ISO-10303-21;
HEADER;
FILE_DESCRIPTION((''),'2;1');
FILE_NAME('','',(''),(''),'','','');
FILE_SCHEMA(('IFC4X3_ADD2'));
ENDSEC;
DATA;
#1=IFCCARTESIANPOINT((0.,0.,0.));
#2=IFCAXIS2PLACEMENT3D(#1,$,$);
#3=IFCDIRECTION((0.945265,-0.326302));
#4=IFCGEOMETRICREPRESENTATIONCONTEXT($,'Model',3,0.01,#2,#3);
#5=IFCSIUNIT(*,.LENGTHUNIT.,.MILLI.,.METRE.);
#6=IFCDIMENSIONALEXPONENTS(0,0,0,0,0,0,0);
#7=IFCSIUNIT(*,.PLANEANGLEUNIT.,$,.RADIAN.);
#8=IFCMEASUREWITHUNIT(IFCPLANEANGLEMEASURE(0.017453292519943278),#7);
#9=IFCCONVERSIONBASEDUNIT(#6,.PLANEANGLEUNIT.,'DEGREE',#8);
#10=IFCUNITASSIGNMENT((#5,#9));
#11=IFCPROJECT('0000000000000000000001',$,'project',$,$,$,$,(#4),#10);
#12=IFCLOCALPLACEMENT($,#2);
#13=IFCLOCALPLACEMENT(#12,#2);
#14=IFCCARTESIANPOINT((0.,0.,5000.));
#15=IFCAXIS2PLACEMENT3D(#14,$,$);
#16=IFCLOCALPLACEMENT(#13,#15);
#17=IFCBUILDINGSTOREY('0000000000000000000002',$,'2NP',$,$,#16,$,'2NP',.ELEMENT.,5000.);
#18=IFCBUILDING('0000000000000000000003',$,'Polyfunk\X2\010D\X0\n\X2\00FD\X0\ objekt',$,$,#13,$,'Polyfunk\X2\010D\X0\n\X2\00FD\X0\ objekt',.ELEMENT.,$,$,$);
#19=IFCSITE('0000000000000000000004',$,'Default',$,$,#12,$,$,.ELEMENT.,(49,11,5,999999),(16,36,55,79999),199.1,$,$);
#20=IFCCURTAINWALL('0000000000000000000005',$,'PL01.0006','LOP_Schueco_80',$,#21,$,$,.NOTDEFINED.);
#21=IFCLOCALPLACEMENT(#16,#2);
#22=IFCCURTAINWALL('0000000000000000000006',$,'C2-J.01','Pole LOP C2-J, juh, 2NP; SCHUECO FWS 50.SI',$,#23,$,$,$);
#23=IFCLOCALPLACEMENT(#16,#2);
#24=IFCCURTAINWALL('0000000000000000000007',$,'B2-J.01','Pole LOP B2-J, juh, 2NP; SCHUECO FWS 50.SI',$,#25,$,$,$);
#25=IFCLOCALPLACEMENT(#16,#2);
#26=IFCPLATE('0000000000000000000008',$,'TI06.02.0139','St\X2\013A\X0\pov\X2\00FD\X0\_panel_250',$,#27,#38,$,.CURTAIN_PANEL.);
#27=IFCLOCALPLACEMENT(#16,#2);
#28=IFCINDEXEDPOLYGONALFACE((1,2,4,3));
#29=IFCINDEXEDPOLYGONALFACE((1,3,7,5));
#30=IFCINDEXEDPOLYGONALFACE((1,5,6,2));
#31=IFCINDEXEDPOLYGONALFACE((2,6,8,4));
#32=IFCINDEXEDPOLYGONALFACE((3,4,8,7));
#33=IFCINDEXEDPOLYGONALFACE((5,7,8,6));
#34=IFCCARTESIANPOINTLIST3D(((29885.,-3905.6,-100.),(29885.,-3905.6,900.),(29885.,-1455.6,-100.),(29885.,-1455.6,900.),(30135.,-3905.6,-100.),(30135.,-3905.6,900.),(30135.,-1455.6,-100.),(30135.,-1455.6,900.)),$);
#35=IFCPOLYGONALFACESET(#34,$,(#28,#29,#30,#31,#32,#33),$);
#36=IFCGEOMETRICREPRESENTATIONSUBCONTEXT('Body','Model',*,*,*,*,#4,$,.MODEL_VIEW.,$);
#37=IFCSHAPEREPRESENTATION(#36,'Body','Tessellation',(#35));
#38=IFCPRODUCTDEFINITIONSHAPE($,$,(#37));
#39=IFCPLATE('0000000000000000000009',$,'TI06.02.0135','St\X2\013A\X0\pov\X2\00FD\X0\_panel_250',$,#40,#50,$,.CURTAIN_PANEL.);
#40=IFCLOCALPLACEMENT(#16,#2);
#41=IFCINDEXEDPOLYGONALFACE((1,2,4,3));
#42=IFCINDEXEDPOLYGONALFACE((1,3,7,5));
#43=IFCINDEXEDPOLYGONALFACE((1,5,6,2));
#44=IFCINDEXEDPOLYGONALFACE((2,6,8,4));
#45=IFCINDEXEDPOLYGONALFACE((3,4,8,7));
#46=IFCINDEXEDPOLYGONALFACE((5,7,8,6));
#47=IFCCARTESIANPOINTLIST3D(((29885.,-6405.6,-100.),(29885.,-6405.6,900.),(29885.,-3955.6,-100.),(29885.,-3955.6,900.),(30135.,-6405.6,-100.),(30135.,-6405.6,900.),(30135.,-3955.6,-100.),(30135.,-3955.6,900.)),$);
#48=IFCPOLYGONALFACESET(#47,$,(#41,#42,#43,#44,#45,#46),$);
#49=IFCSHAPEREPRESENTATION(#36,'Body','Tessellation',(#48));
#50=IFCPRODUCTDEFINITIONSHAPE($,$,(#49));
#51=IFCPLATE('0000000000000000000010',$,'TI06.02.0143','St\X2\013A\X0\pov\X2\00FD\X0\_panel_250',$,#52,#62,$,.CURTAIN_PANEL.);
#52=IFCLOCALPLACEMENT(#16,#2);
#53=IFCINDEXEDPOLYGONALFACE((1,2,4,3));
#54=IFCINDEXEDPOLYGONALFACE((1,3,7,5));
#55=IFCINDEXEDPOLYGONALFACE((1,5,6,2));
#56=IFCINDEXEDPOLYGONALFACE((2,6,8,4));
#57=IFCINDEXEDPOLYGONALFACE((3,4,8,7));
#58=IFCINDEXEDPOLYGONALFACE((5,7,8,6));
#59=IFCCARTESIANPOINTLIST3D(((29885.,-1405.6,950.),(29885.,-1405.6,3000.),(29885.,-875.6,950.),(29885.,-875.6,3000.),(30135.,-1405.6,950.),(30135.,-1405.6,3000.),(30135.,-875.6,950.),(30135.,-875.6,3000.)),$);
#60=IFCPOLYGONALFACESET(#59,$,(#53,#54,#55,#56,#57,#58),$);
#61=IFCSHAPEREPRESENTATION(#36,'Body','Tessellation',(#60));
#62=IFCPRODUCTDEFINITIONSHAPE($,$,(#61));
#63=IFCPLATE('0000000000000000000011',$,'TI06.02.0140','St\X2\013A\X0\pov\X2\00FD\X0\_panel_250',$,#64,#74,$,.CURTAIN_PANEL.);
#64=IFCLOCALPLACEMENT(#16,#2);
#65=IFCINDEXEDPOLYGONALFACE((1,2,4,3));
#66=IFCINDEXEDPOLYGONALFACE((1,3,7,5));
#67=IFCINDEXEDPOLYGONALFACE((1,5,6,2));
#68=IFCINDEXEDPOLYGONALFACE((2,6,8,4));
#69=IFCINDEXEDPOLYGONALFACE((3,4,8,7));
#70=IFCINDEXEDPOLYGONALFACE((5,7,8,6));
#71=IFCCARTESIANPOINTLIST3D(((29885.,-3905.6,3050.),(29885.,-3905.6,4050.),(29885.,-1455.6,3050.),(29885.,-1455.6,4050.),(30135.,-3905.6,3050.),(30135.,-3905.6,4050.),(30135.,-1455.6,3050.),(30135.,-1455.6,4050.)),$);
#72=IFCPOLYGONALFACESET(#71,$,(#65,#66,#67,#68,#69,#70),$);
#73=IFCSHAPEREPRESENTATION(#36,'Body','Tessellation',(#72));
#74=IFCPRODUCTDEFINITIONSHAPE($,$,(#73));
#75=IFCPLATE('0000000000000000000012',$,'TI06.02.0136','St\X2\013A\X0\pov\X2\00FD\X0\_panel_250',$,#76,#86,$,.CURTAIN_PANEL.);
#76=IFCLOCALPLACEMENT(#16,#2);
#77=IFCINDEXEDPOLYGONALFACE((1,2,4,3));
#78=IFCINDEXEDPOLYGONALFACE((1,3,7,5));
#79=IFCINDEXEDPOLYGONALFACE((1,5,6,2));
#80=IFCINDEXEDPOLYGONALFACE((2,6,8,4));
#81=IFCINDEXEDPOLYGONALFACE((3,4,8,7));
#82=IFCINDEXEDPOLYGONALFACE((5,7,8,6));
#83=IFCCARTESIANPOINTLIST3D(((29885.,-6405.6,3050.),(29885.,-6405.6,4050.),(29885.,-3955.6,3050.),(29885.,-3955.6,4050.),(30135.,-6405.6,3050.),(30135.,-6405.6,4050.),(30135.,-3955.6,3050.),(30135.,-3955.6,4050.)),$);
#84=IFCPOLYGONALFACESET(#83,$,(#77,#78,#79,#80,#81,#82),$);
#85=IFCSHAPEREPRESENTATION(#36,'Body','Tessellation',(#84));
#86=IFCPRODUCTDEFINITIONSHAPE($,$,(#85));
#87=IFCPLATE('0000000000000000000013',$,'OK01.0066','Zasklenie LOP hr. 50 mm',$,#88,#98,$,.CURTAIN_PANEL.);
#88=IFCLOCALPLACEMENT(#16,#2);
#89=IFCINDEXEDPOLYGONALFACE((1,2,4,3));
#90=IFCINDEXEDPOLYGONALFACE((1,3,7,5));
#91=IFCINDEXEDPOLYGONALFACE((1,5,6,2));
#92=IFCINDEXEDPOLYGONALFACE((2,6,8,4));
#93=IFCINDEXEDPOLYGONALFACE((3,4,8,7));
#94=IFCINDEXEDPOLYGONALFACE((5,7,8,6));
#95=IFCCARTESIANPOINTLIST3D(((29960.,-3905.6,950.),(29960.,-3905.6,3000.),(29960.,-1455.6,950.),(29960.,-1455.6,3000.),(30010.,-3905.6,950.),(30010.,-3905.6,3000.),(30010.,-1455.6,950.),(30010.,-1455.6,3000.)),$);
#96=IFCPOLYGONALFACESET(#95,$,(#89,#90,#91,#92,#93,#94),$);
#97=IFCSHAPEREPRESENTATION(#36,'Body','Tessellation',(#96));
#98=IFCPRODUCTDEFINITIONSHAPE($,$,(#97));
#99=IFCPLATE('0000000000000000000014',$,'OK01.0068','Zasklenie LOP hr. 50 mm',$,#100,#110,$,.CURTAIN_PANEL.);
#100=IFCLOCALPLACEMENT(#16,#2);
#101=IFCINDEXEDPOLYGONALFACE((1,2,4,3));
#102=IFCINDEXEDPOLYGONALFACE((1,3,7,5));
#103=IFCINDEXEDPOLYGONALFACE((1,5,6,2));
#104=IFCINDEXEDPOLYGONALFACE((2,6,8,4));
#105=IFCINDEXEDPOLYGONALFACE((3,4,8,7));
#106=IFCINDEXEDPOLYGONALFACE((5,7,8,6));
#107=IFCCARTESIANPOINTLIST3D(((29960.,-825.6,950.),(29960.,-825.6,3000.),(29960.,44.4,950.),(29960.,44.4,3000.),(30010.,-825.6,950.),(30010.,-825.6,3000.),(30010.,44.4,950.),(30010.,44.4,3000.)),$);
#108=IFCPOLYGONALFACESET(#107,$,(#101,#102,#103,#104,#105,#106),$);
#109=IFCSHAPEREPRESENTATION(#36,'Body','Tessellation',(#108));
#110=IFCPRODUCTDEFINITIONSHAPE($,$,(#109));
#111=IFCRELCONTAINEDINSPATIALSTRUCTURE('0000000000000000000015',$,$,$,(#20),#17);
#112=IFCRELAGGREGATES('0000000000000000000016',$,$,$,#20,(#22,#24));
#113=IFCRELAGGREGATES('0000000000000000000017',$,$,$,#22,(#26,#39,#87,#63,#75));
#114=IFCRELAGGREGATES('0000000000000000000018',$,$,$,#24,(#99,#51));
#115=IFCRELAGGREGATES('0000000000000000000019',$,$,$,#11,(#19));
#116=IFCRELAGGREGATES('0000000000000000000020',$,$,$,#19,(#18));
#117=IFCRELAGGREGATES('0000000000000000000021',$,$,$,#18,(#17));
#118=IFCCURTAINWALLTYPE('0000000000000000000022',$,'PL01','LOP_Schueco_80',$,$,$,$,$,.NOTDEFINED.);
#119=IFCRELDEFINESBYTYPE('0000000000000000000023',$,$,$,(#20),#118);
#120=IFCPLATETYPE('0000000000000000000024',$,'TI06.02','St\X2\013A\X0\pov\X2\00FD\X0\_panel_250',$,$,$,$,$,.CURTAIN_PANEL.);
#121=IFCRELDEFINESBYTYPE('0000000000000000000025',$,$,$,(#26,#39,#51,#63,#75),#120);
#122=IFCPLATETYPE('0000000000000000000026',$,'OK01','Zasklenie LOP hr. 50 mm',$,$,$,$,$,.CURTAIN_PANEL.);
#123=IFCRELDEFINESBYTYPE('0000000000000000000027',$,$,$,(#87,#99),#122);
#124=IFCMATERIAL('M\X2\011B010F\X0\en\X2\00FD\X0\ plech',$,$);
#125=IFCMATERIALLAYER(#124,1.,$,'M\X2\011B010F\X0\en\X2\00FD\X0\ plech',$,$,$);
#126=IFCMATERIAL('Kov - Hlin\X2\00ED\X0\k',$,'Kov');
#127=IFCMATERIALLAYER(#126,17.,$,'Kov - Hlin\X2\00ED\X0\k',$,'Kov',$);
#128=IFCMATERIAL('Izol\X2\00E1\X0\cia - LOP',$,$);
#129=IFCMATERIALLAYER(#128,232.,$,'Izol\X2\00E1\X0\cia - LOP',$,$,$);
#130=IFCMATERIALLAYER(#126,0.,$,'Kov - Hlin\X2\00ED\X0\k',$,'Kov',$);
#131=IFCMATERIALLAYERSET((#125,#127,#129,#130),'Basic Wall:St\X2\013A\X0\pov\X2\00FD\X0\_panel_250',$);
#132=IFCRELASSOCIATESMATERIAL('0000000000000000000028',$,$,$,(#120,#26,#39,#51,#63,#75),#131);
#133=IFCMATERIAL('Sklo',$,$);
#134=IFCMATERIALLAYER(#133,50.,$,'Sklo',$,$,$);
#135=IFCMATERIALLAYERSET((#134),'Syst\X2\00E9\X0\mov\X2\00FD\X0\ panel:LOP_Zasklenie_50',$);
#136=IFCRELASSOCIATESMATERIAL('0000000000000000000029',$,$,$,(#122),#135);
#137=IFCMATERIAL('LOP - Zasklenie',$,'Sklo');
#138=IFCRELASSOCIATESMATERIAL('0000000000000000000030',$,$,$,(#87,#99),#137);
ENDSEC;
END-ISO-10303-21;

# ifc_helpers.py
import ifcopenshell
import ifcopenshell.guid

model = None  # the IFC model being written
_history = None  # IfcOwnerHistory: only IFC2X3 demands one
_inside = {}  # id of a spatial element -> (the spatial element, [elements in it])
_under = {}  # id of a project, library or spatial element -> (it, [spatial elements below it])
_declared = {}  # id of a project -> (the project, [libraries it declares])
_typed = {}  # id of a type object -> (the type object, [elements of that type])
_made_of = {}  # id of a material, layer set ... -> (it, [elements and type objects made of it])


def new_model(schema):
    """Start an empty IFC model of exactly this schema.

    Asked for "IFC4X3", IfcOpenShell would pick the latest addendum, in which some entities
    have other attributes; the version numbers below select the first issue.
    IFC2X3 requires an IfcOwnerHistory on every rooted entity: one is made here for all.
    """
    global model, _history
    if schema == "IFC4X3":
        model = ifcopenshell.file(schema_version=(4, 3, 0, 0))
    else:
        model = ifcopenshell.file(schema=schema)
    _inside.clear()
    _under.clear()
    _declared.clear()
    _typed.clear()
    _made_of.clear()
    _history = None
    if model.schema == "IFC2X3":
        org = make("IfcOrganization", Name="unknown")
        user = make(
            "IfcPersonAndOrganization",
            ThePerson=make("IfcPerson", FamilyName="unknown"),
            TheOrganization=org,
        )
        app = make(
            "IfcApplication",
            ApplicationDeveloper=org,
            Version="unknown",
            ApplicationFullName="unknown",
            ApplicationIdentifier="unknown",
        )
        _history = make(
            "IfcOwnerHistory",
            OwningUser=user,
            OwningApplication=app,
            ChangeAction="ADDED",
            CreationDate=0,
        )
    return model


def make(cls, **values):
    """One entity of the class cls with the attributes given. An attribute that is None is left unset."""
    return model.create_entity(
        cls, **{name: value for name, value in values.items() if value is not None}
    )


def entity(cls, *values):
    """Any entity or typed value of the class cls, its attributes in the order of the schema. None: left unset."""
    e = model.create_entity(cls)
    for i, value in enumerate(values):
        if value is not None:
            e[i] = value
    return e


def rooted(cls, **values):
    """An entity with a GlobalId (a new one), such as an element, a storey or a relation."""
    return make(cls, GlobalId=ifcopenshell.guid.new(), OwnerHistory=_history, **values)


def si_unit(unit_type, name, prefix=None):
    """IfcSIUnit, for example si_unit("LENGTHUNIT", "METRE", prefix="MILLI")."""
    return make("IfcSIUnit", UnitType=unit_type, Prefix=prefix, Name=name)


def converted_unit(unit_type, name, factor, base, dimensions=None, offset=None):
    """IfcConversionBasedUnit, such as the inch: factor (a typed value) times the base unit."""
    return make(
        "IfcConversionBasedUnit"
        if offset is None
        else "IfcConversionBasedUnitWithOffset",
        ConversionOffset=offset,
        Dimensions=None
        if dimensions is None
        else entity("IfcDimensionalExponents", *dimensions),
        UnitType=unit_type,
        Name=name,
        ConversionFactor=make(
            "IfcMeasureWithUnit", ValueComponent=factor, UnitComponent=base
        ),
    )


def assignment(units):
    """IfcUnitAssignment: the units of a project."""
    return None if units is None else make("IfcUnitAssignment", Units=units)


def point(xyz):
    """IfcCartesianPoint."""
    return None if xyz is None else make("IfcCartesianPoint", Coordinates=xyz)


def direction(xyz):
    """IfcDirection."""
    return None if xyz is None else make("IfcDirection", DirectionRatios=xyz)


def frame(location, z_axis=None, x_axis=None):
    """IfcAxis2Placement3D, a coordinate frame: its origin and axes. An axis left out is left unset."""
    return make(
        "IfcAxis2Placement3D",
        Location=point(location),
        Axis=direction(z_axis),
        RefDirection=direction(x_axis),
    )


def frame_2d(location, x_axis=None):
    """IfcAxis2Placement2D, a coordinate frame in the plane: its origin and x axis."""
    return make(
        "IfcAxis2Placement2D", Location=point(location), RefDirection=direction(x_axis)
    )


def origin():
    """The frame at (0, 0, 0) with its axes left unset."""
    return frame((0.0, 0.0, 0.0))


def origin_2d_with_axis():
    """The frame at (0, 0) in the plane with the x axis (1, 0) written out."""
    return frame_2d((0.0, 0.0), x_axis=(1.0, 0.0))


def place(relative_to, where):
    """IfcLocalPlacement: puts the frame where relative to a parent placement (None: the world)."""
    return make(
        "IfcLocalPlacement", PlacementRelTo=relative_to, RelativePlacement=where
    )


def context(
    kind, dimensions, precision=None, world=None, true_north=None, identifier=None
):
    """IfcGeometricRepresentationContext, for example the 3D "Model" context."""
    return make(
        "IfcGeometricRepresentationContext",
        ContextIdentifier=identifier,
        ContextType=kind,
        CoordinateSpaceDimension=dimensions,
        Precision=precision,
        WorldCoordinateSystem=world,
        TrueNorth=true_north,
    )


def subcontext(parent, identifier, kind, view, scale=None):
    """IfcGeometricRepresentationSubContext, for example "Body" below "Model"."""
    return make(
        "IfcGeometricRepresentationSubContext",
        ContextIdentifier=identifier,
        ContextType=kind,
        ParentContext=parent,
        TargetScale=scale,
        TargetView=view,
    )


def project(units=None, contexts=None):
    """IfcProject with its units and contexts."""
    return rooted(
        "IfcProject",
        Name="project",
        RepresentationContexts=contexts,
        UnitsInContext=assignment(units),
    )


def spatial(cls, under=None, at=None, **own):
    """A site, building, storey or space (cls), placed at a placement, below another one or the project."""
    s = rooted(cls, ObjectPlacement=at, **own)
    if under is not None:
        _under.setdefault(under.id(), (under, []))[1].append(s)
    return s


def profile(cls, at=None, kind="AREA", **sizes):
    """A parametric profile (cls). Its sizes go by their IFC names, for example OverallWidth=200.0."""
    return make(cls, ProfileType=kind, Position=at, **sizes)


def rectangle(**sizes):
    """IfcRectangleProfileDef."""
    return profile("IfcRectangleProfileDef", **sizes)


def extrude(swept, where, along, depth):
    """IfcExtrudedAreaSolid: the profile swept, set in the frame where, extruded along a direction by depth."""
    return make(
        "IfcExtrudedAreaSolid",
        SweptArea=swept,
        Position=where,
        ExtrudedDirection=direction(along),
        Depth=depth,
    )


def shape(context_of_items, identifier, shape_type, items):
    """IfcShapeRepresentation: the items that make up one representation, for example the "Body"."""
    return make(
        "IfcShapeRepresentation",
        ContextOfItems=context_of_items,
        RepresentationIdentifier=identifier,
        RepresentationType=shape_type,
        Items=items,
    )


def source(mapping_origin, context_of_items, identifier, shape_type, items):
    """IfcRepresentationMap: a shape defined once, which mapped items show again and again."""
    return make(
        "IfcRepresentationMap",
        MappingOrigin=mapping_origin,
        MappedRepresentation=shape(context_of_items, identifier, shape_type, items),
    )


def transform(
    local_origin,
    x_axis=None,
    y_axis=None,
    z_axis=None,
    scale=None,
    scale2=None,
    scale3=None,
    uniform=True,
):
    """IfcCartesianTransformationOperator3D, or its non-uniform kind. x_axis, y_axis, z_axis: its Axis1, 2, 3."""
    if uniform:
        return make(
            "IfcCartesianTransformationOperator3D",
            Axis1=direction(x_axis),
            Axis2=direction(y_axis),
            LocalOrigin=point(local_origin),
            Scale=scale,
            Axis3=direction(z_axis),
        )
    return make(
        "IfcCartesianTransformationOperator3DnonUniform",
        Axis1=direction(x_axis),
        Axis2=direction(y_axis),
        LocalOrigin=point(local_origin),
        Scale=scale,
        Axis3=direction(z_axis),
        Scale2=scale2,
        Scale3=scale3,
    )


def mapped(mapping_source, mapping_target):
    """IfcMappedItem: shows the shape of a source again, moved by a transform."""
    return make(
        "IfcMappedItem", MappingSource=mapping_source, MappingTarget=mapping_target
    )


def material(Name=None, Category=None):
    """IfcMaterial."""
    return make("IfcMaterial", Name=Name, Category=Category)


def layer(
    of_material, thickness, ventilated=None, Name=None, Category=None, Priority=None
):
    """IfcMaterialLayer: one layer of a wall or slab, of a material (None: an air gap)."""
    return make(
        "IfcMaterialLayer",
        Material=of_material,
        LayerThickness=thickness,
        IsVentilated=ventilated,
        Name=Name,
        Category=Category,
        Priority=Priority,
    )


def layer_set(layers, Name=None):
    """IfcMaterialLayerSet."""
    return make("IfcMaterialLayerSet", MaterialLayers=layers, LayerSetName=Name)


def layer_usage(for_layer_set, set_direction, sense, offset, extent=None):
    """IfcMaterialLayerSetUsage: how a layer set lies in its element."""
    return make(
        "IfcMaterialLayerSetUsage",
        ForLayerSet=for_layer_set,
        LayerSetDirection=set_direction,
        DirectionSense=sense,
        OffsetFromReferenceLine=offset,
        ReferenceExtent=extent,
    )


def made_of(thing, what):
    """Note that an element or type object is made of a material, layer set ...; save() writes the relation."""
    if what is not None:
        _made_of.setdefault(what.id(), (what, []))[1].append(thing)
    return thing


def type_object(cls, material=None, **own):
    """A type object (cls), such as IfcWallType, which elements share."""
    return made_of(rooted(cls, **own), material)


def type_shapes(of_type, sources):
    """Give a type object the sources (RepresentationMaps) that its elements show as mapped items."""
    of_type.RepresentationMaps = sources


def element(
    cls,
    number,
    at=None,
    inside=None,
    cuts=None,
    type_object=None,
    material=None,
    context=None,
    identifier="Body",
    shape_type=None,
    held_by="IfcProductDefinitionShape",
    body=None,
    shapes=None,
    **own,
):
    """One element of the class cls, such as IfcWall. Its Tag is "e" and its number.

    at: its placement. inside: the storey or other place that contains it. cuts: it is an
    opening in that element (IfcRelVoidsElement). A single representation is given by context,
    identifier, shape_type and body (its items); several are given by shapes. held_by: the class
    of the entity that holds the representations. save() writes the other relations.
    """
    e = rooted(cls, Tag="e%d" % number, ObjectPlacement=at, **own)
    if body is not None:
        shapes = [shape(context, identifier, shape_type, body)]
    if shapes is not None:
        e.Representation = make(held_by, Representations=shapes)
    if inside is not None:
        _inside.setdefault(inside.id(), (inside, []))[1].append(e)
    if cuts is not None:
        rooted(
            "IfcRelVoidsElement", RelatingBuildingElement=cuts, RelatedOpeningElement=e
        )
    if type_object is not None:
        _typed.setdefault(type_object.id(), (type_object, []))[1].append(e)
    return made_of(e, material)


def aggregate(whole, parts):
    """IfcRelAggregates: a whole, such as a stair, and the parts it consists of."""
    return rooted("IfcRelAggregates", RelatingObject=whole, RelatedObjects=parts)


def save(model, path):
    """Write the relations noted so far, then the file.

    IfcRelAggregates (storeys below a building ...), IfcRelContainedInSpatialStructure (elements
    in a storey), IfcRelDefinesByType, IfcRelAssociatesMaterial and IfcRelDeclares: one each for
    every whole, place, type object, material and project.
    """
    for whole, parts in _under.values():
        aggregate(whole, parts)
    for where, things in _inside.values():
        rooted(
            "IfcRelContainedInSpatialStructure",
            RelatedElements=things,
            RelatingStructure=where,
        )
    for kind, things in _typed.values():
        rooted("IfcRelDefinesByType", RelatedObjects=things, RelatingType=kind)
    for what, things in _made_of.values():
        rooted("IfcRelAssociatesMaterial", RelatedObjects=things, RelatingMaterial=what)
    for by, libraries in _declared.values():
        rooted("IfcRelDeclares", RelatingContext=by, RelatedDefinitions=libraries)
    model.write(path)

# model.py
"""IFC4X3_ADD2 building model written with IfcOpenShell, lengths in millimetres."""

from ifc_helpers import new_model, entity, si_unit, converted_unit, direction, frame, frame_2d, origin, origin_2d_with_axis, place, context, subcontext, project, spatial, rectangle, extrude, source, transform, mapped, material, layer, layer_set, layer_usage, type_object, type_shapes, element, aggregate, save


model = new_model("IFC4X3_ADD2")

# Units and contexts
model_context = context("Model", 3, precision=0.01, world=origin(), true_north=direction((0.945265, -0.326302)))
body_context = subcontext(model_context, "Body", "Model", "MODEL_VIEW")
ifc_project = project(units=[si_unit("LENGTHUNIT", "METRE", prefix="MILLI"), converted_unit("PLANEANGLEUNIT", "DEGREE", entity("IfcPlaneAngleMeasure", 0.017453292519943278), si_unit("PLANEANGLEUNIT", "RADIAN"), dimensions=[0, 0, 0, 0, 0, 0, 0])], contexts=[model_context])

# Site, building, storey
site_placement = place(None, origin())
site = spatial("IfcSite", under=ifc_project, at=site_placement, Name="Default", CompositionType="ELEMENT", RefLatitude=(49, 11, 5, 999999), RefLongitude=(16, 36, 55, 79999), RefElevation=199.1)
building_placement = place(site_placement, origin())
building = spatial("IfcBuilding", under=site, at=building_placement, Name="Polyfunkčný objekt", LongName="Polyfunkčný objekt", CompositionType="ELEMENT")
storey_placement = place(building_placement, frame((0.0, 0.0, 5000.0)))
storey = spatial("IfcBuildingStorey", under=building, at=storey_placement, Name="2NP", LongName="2NP", CompositionType="ELEMENT", Elevation=5000.0)

# Curtain walls, plates
curtain_wall_type = type_object("IfcCurtainWallType", Name="PL01", Description="LOP_Schueco_80", PredefinedType="NOTDEFINED")
curtain_wall_1_placement = place(storey_placement, frame((0.0, 0.0, -5000.0)))
curtain_wall_1 = element("IfcCurtainWall", 1, at=curtain_wall_1_placement, inside=storey, type_object=curtain_wall_type, Name="PL01.0006", Description="LOP_Schueco_80", PredefinedType="NOTDEFINED")
curtain_wall_2 = element("IfcCurtainWall", 2, Name="C2-J.01", Description="Pole LOP C2-J, juh, 2NP; SCHUECO FWS 50.SI")
curtain_wall_3 = element("IfcCurtainWall", 3, Name="B2-J.01", Description="Pole LOP B2-J, juh, 2NP; SCHUECO FWS 50.SI")
aggregate(curtain_wall_1, [curtain_wall_2, curtain_wall_3])
ifc_material_1 = material(Name="Měďený plech")
ifc_layer_1 = layer(ifc_material_1, 1.0, Name="Měďený plech")
ifc_material_2 = material(Name="Kov - Hliník", Category="Kov")
ifc_layer_2 = layer(ifc_material_2, 17.0, Name="Kov - Hliník", Category="Kov")
ifc_material_3 = material(Name="Izolácia - LOP")
ifc_layer_3 = layer(ifc_material_3, 232.0, Name="Izolácia - LOP")
ifc_layer_4 = layer(ifc_material_2, 0.0, Name="Kov - Hliník", Category="Kov")
ifc_layer_set_1 = layer_set([ifc_layer_1, ifc_layer_2, ifc_layer_3, ifc_layer_4], Name="Basic Wall:Stĺpový_panel_250")
ifc_layer_usage_1 = layer_usage(ifc_layer_set_1, "AXIS2", "POSITIVE", -125.0)
plate_type_1 = type_object("IfcPlateType", Name="TI06.02", Description="Stĺpový_panel_250", PredefinedType="CURTAIN_PANEL", material=ifc_layer_set_1)
plate_1_placement = place(storey_placement, frame((30010.0, -1455.6, -100.0), z_axis=(0.0, 0.0, 1.0), x_axis=(0.0, -1.0, 0.0)))
plate_1 = element("IfcPlate", 4, at=plate_1_placement, type_object=plate_type_1, material=ifc_layer_usage_1, Name="TI06.02.0139", Description="Stĺpový_panel_250", PredefinedType="CURTAIN_PANEL", context=body_context, shape_type="SweptSolid", body=[
    extrude(rectangle(XDim=250.0, YDim=2450.0, at=origin_2d_with_axis()), frame((1225.0, 0.0, 0.0), z_axis=(0.0, 0.0, 1.0), x_axis=(0.0, 1.0, 0.0)), (0.0, 0.0, 1.0), 1000.0),
])
ifc_layer_usage_2 = layer_usage(ifc_layer_set_1, "AXIS2", "POSITIVE", -125.0)
plate_2_placement = place(storey_placement, frame((30010.0, -3955.6, -100.0), z_axis=(0.0, 0.0, 1.0), x_axis=(0.0, -1.0, 0.0)))
plate_2 = element("IfcPlate", 5, at=plate_2_placement, type_object=plate_type_1, material=ifc_layer_usage_2, Name="TI06.02.0135", Description="Stĺpový_panel_250", PredefinedType="CURTAIN_PANEL", context=body_context, shape_type="SweptSolid", body=[
    extrude(rectangle(XDim=250.0, YDim=2450.0, at=frame_2d((0.0, 0.0), x_axis=(1.0, 0.0))), frame((1225.0, 0.0, 0.0), z_axis=(0.0, 0.0, 1.0), x_axis=(0.0, 1.0, 0.0)), (0.0, 0.0, 1.0), 1000.0),
])
ifc_layer_usage_3 = layer_usage(ifc_layer_set_1, "AXIS2", "POSITIVE", -125.0)
plate_3_placement = place(storey_placement, frame((30010.0, -875.6, 950.0), z_axis=(0.0, 0.0, 1.0), x_axis=(0.0, -1.0, 0.0)))
plate_3 = element("IfcPlate", 6, at=plate_3_placement, type_object=plate_type_1, material=ifc_layer_usage_3, Name="TI06.02.0143", Description="Stĺpový_panel_250", PredefinedType="CURTAIN_PANEL", context=body_context, shape_type="SweptSolid", body=[
    extrude(rectangle(XDim=250.0, YDim=530.0, at=frame_2d((0.0, 0.0), x_axis=(1.0, 0.0))), frame((265.0, 0.0, 0.0), z_axis=(0.0, 0.0, 1.0), x_axis=(0.0, 1.0, 0.0)), (0.0, 0.0, 1.0), 2050.0),
])
ifc_layer_usage_4 = layer_usage(ifc_layer_set_1, "AXIS2", "POSITIVE", -125.0)
plate_4_placement = place(storey_placement, frame((30010.0, -1455.6, 3050.0), z_axis=(0.0, 0.0, 1.0), x_axis=(0.0, -1.0, 0.0)))
plate_4 = element("IfcPlate", 7, at=plate_4_placement, type_object=plate_type_1, material=ifc_layer_usage_4, Name="TI06.02.0140", Description="Stĺpový_panel_250", PredefinedType="CURTAIN_PANEL", context=body_context, shape_type="SweptSolid", body=[
    extrude(rectangle(XDim=250.0, YDim=2450.0, at=origin_2d_with_axis()), frame((1225.0, 0.0, 0.0), z_axis=(0.0, 0.0, 1.0), x_axis=(0.0, 1.0, 0.0)), (0.0, 0.0, 1.0), 1000.0),
])
ifc_layer_usage_5 = layer_usage(ifc_layer_set_1, "AXIS2", "POSITIVE", -125.0)
plate_5_placement = place(storey_placement, frame((30010.0, -3955.6, 3050.0), z_axis=(0.0, 0.0, 1.0), x_axis=(0.0, -1.0, 0.0)))
plate_5 = element("IfcPlate", 8, at=plate_5_placement, type_object=plate_type_1, material=ifc_layer_usage_5, Name="TI06.02.0136", Description="Stĺpový_panel_250", PredefinedType="CURTAIN_PANEL", context=body_context, shape_type="SweptSolid", body=[
    extrude(rectangle(XDim=250.0, YDim=2450.0, at=frame_2d((0.0, 0.0), x_axis=(1.0, 0.0))), frame((1225.0, 0.0, 0.0), z_axis=(0.0, 0.0, 1.0), x_axis=(0.0, 1.0, 0.0)), (0.0, 0.0, 1.0), 1000.0),
])
ifc_material_4 = material(Name="LOP - Zasklenie", Category="Sklo")
ifc_material_5 = material(Name="Sklo")
ifc_layer_5 = layer(ifc_material_5, 50.0, Name="Sklo")
ifc_layer_set_2 = layer_set([ifc_layer_5], Name="Systémový panel:LOP_Zasklenie_50")
plate_type_2 = type_object("IfcPlateType", Name="OK01", Description="Zasklenie LOP hr. 50 mm", PredefinedType="CURTAIN_PANEL", material=ifc_layer_set_2)
shared_shape_1 = source(origin(), body_context, "Body", "SweptSolid", [
    extrude(rectangle(XDim=50.0, YDim=2450.0, at=origin_2d_with_axis()), frame((0.0, -25.0, 0.0), z_axis=(0.0, 0.0, 1.0), x_axis=(0.0, 1.0, 0.0)), (0.0, 0.0, 1.0), 2050.0),
])
plate_6_placement = place(curtain_wall_1_placement, frame((30010.0, -2680.6, 5950.0), z_axis=(0.0, 0.0, 1.0), x_axis=(0.0, -1.0, 0.0)))
plate_6 = element("IfcPlate", 9, at=plate_6_placement, type_object=plate_type_2, material=ifc_material_4, Name="OK01.0066", Description="Zasklenie LOP hr. 50 mm", PredefinedType="CURTAIN_PANEL", context=body_context, shape_type="MappedRepresentation", body=[
    mapped(shared_shape_1, transform((0.0, 0.0, 0.0), scale=1.0)),
])
aggregate(curtain_wall_2, [plate_1, plate_2, plate_6, plate_4, plate_5])
shared_shape_2 = source(origin(), body_context, "Body", "SweptSolid", [
    extrude(rectangle(XDim=50.0, YDim=870.0, at=origin_2d_with_axis()), frame((0.0, -25.0, 0.0), z_axis=(0.0, 0.0, 1.0), x_axis=(0.0, 1.0, 0.0)), (0.0, 0.0, 1.0), 2050.0),
])
type_shapes(plate_type_2, [shared_shape_1, shared_shape_2])
plate_7_placement = place(curtain_wall_1_placement, frame((30010.0, -390.6, 5950.0), z_axis=(0.0, 0.0, 1.0), x_axis=(0.0, -1.0, 0.0)))
plate_7 = element("IfcPlate", 10, at=plate_7_placement, type_object=plate_type_2, material=ifc_material_4, Name="OK01.0068", Description="Zasklenie LOP hr. 50 mm", PredefinedType="CURTAIN_PANEL", context=body_context, shape_type="MappedRepresentation", body=[
    mapped(shared_shape_2, transform((0.0, 0.0, 0.0), scale=1.0)),
])
aggregate(curtain_wall_3, [plate_7, plate_3])

save(model, "model.ifc")
